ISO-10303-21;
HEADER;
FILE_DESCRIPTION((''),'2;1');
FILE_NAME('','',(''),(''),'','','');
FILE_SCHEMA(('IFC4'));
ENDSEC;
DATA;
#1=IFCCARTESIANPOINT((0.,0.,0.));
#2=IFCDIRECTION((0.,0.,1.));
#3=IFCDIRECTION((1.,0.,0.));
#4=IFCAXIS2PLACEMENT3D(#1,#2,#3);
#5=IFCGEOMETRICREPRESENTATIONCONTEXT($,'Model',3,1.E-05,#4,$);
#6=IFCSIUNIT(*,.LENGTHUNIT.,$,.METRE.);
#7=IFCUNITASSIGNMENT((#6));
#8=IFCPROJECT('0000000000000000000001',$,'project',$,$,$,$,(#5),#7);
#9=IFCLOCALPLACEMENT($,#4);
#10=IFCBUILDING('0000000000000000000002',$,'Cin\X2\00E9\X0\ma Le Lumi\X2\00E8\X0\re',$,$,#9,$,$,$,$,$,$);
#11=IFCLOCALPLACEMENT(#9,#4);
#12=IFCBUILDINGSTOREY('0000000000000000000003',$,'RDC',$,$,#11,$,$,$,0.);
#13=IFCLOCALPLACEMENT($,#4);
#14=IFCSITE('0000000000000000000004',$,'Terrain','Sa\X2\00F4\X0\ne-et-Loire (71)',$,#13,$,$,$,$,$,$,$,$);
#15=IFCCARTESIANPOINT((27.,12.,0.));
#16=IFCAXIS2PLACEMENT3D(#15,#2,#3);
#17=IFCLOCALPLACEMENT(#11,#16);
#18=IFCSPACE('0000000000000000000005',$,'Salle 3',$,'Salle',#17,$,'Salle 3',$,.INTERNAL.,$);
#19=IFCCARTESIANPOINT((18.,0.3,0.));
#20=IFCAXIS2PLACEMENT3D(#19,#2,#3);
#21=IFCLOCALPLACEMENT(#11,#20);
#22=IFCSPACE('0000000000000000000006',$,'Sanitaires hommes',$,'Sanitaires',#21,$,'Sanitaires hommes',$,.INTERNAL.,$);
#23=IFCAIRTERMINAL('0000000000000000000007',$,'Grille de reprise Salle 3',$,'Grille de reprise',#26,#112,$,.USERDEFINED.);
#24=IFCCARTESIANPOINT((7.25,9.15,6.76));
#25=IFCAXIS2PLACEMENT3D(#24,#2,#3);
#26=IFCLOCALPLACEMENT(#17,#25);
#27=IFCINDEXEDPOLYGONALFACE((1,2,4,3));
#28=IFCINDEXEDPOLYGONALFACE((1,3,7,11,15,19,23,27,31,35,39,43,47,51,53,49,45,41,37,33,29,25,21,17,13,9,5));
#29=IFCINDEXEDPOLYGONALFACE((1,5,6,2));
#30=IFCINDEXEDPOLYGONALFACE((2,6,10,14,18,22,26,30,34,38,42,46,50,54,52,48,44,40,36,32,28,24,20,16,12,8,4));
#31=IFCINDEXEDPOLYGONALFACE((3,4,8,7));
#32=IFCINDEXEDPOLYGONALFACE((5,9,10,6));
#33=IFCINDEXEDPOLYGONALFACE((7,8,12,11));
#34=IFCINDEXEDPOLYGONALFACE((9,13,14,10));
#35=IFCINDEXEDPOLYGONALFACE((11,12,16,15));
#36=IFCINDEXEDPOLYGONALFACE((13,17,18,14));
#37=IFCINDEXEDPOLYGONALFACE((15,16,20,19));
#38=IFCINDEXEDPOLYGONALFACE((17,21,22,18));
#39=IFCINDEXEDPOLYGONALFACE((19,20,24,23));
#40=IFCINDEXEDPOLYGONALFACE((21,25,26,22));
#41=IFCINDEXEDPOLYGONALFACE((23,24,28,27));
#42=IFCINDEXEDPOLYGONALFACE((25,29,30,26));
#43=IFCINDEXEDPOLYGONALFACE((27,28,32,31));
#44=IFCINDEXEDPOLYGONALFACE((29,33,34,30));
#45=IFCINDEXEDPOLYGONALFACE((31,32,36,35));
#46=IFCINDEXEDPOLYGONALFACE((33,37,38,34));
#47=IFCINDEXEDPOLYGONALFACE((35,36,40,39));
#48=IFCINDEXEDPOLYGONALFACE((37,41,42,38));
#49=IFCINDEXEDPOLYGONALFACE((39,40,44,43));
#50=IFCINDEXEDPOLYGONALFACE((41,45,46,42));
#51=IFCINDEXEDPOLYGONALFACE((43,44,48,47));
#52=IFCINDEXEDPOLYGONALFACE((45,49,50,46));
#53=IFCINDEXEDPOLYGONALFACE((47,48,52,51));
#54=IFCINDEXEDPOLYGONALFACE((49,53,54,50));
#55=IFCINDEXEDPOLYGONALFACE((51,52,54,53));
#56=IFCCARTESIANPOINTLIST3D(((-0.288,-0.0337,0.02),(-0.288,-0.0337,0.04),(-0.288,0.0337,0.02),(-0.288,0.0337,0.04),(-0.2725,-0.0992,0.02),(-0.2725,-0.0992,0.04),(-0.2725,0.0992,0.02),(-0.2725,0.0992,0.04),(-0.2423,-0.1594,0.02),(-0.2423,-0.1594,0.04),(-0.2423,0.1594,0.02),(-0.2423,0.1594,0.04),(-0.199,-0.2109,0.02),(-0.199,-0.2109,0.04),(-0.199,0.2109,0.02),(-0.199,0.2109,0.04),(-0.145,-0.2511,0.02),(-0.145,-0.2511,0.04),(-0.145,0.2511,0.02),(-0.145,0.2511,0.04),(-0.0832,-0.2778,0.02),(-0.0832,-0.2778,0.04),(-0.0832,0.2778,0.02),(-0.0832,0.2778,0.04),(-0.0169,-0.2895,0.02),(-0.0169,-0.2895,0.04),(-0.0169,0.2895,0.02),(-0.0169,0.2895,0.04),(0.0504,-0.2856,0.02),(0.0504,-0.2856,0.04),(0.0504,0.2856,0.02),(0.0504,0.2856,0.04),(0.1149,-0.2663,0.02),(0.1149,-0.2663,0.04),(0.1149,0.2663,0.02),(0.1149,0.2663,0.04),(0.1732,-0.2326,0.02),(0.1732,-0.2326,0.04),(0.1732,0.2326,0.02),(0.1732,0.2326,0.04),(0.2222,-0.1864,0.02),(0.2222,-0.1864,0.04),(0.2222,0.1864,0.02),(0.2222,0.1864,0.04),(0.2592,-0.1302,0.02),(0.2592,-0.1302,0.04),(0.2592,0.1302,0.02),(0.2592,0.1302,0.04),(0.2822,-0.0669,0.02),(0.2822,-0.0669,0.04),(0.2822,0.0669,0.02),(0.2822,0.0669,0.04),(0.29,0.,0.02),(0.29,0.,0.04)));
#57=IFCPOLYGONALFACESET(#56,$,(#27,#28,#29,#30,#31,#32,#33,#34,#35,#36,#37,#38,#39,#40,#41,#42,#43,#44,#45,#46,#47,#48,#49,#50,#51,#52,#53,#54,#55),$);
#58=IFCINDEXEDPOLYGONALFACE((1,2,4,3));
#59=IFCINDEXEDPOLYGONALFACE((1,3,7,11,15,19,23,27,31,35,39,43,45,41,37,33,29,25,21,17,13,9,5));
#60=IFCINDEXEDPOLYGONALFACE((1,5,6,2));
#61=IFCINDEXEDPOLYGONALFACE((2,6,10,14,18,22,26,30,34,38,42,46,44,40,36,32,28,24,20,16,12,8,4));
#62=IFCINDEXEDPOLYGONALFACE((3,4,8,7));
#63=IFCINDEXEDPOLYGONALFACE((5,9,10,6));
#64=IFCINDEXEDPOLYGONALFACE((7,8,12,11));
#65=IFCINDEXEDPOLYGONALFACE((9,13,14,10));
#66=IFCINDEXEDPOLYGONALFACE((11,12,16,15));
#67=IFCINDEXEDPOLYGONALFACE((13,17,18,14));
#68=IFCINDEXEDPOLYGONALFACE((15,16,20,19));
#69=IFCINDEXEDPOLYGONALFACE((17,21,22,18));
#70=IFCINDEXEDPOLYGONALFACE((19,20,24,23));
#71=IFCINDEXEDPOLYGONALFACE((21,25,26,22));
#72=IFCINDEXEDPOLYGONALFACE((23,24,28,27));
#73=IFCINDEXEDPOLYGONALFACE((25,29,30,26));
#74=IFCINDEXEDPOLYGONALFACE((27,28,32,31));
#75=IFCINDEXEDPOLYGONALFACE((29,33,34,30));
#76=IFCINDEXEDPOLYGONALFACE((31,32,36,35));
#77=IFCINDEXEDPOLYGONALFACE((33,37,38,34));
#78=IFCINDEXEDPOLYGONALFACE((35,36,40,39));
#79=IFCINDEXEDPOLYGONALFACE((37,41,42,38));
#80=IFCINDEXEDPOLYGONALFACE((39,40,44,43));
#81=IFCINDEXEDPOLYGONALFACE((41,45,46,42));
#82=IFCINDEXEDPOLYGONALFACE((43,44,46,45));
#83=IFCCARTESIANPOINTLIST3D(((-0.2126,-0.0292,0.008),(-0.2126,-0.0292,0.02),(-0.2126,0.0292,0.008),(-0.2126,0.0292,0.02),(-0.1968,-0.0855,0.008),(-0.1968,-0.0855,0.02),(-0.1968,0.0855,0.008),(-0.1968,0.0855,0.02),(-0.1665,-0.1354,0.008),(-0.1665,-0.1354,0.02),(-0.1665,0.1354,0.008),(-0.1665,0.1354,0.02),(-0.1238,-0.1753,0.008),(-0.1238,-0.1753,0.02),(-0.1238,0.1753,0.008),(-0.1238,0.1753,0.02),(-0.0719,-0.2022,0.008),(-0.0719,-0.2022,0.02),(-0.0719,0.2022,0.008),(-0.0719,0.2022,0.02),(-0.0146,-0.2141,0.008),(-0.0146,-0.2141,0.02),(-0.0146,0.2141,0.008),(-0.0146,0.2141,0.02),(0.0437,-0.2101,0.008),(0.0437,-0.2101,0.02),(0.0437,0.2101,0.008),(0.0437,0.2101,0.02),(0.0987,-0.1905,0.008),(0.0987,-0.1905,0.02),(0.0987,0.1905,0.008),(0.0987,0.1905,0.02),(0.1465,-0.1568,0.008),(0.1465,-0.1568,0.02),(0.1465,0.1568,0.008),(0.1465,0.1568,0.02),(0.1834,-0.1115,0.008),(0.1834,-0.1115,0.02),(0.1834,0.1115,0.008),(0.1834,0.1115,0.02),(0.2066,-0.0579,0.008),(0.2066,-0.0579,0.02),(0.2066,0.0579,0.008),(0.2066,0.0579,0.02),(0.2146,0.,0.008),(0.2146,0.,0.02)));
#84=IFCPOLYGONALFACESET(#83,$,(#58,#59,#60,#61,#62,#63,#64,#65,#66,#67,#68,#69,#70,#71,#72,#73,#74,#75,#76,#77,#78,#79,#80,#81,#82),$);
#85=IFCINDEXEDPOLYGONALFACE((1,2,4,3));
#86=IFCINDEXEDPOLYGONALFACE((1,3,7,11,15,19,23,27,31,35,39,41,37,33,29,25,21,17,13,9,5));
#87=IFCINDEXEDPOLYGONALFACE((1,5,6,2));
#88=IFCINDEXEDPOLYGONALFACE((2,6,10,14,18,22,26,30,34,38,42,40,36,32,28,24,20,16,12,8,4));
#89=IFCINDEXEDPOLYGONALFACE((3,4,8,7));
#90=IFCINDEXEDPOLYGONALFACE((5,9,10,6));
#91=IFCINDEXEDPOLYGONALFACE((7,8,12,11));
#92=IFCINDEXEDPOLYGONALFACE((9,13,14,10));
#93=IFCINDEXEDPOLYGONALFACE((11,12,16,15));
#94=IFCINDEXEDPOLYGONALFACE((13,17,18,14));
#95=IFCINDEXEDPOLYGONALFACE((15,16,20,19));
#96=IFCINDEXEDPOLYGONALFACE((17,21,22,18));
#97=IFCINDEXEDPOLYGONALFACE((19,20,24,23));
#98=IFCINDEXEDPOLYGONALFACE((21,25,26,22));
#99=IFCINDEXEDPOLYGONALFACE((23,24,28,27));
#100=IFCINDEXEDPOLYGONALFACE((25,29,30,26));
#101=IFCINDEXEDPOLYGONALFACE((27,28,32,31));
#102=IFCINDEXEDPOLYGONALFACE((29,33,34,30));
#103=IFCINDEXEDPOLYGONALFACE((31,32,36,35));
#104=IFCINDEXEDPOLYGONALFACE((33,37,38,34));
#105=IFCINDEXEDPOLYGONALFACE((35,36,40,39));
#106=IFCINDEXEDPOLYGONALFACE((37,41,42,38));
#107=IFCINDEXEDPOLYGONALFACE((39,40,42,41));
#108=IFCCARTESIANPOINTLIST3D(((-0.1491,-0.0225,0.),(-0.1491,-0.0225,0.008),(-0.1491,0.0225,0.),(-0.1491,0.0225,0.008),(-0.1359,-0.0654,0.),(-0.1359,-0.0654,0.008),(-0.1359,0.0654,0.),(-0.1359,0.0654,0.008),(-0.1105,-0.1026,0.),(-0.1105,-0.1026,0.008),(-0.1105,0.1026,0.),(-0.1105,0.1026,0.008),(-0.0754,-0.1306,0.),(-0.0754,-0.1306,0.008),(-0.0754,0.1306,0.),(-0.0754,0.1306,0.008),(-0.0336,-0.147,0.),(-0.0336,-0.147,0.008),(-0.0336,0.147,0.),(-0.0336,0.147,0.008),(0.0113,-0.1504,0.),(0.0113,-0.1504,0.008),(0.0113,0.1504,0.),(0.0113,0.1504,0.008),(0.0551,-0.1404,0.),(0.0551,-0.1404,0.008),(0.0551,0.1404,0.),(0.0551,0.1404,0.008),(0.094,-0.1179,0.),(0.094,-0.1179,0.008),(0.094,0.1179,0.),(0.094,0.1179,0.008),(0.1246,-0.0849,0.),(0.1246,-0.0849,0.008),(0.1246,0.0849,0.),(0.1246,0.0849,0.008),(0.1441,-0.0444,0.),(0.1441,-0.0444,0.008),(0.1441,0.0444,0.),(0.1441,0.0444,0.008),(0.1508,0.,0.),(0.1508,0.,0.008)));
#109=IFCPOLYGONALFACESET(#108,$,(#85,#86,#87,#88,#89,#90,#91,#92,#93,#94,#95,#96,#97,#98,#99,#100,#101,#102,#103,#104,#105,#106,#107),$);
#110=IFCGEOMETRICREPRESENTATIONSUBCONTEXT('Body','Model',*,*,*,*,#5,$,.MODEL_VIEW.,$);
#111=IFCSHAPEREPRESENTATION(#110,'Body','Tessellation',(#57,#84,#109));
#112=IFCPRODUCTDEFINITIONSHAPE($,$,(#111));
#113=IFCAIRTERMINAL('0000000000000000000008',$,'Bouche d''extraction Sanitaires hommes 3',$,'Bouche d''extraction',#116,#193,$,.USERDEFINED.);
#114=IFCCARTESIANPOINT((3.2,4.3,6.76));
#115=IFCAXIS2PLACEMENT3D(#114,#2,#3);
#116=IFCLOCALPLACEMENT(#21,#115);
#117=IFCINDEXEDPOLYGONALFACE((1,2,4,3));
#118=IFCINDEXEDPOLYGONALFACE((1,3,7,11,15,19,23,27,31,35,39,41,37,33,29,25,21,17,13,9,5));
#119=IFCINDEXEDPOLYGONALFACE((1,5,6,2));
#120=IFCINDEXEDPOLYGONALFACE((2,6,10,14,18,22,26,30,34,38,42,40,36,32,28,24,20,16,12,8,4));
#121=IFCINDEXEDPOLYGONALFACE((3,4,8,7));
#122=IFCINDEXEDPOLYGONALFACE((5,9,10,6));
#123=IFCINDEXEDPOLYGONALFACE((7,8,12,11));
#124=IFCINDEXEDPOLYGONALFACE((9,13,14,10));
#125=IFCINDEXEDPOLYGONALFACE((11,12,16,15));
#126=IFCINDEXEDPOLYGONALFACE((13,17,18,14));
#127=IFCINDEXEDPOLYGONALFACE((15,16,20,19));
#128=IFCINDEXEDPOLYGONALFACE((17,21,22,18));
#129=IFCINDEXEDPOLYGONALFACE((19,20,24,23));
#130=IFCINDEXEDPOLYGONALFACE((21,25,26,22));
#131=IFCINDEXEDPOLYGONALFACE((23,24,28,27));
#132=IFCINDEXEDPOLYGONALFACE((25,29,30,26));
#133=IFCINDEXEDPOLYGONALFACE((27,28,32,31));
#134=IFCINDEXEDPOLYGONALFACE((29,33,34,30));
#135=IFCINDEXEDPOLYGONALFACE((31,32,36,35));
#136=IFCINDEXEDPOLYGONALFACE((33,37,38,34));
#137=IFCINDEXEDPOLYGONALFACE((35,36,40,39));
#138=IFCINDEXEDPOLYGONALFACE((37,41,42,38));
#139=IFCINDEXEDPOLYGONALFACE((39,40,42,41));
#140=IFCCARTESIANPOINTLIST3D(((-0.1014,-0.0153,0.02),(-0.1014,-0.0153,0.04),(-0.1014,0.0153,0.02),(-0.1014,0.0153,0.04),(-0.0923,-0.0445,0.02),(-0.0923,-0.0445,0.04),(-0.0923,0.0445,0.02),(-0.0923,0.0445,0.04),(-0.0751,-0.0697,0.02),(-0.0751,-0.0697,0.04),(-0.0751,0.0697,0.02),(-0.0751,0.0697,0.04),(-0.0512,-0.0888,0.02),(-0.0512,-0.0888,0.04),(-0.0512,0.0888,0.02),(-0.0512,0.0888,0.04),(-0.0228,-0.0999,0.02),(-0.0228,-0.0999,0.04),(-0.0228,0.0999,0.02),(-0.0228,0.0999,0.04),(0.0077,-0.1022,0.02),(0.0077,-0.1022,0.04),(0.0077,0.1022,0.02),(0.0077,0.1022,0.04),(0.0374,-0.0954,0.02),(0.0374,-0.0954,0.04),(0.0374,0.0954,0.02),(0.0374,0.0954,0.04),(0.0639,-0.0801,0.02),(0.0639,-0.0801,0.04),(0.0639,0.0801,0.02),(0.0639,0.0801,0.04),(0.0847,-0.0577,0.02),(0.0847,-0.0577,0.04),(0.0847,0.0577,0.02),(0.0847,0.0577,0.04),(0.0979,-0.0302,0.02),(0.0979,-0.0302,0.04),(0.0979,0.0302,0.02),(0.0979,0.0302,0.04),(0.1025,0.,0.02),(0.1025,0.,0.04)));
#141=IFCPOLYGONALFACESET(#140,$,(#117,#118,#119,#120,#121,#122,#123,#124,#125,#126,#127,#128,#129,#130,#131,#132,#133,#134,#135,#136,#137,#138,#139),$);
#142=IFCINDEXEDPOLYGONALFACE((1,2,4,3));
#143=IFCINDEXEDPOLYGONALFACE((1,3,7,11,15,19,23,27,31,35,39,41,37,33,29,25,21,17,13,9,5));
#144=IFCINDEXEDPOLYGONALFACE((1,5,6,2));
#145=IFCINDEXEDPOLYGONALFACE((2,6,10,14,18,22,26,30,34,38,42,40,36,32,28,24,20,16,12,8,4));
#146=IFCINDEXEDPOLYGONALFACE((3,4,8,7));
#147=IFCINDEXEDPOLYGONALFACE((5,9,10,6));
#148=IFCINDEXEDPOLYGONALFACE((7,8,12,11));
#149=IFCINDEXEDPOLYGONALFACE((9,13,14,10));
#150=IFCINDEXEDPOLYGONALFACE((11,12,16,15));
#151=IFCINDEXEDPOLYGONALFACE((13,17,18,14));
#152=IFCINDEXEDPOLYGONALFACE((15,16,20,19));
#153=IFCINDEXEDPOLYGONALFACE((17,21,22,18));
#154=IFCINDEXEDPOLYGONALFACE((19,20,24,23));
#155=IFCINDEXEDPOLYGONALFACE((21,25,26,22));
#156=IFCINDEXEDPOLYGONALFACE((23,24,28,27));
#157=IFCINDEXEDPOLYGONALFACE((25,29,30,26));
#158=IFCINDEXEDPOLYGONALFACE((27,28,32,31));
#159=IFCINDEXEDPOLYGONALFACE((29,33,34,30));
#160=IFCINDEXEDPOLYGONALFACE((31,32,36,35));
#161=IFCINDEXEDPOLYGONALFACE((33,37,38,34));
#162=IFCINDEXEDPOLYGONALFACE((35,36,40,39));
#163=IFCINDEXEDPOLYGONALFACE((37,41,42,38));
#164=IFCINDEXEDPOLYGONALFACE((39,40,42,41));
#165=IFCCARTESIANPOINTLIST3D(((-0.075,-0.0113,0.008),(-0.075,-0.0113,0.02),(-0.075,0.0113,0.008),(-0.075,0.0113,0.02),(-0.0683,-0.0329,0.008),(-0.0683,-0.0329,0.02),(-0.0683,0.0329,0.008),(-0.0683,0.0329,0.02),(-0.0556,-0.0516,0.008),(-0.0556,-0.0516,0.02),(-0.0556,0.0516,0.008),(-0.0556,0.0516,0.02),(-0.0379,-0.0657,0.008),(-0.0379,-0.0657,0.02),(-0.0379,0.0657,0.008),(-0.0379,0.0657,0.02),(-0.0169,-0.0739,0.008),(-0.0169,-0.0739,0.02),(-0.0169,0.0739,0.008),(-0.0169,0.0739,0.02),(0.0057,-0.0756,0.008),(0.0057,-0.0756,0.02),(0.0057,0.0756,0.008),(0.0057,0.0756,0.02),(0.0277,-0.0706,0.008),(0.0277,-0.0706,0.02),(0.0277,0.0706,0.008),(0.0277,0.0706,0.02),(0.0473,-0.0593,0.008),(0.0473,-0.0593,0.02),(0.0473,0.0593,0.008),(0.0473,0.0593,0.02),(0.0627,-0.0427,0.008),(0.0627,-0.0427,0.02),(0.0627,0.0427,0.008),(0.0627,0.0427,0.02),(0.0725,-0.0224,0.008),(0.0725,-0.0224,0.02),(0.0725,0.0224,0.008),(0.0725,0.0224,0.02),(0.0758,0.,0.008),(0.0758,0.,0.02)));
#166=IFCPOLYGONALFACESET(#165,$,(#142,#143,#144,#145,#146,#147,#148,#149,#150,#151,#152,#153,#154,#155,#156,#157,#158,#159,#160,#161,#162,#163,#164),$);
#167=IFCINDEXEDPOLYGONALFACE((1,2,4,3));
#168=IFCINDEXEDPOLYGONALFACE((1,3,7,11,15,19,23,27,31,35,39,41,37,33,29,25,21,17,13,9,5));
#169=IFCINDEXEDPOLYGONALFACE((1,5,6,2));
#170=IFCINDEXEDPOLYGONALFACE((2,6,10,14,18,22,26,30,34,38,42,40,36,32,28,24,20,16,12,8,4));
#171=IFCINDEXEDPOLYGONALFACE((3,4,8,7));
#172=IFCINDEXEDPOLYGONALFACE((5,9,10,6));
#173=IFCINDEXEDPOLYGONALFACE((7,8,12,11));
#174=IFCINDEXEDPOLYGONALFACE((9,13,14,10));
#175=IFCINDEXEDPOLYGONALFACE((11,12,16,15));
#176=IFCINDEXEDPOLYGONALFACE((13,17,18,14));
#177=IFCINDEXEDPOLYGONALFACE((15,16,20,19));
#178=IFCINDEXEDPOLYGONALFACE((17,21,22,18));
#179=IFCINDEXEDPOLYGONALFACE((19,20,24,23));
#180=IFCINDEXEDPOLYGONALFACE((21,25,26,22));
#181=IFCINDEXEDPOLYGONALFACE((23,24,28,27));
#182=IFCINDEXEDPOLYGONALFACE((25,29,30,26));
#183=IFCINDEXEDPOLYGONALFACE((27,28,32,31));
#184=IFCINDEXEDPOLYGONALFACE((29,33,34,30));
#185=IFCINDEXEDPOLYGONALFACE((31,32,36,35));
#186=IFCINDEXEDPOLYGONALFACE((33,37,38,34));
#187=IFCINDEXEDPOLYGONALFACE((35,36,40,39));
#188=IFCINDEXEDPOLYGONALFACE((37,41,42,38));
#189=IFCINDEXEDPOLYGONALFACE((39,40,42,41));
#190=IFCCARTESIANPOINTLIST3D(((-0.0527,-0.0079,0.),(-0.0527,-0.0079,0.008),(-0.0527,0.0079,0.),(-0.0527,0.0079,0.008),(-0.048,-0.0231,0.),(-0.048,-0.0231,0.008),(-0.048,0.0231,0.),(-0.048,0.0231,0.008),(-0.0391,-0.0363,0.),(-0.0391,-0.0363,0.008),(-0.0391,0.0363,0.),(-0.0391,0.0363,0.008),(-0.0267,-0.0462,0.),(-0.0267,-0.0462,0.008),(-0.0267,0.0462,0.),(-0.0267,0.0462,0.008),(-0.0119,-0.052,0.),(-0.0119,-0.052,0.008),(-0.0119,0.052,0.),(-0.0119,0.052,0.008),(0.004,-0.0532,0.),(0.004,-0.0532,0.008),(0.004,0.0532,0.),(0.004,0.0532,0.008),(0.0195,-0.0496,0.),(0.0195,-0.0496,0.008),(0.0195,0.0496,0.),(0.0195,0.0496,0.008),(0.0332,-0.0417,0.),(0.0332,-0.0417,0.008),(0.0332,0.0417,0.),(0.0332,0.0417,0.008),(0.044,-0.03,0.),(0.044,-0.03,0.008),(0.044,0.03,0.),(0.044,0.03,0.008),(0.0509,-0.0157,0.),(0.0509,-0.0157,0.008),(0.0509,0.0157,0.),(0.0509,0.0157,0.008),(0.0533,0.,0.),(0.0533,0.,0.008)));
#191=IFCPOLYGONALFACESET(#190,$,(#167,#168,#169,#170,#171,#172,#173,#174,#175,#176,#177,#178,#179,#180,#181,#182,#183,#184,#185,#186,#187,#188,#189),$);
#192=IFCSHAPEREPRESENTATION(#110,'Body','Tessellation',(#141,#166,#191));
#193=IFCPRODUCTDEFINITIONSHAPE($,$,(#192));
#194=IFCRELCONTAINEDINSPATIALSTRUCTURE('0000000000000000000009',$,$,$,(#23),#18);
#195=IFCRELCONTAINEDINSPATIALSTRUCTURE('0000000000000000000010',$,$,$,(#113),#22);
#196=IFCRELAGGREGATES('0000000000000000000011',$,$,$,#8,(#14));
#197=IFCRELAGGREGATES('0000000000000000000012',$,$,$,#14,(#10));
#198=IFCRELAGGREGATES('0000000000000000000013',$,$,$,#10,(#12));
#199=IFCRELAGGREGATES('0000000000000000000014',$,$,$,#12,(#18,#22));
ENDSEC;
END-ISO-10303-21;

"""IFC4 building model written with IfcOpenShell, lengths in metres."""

from ifc_helpers import new_model, si_unit, frame, origin_with_axes, place, context, subcontext, project, spatial, circle, extrude, element, save


model = new_model("IFC4")

# Units and contexts
model_context = context("Model", 3, precision=1e-05, world=origin_with_axes())
body_context = subcontext(model_context, "Body", "Model", "MODEL_VIEW")
ifc_project = project(units=[si_unit("LENGTHUNIT", "METRE")], contexts=[model_context])

# Site, building, storey
site_placement = place(None, origin_with_axes())
site = spatial("IfcSite", under=ifc_project, at=site_placement, Name="Terrain", Description="Saône-et-Loire (71)")
building_placement = place(None, origin_with_axes())
building = spatial("IfcBuilding", under=site, at=building_placement, Name="Cinéma Le Lumière")
storey_placement = place(building_placement, origin_with_axes())
storey = spatial("IfcBuildingStorey", under=building, at=storey_placement, Name="RDC", Elevation=0.0)

# Shared definitions
space_1_placement = place(storey_placement, frame((27.0, 12.0, 0.0), z_axis=(0.0, 0.0, 1.0), x_axis=(1.0, 0.0, 0.0)))
space_1 = spatial("IfcSpace", under=storey, at=space_1_placement, Name="Salle 3", ObjectType="Salle", LongName="Salle 3", PredefinedType="INTERNAL")

# Air terminal
air_terminal_1_placement = place(space_1_placement, frame((7.25, 9.15, 6.76), z_axis=(0.0, 0.0, 1.0), x_axis=(1.0, 0.0, 0.0)))
element("IfcAirTerminal", 1, at=air_terminal_1_placement, inside=space_1, Name="Grille de reprise Salle 3", ObjectType="Grille de reprise", PredefinedType="USERDEFINED", context=body_context, shape_type="SweptSolid", body=[
    extrude(circle(Radius=0.29), frame((0.0, 0.0, 0.02), z_axis=(0.0, 0.0, 1.0), x_axis=(1.0, 0.0, 0.0)), (0.0, 0.0, 1.0), 0.02),
    extrude(circle(Radius=0.2146), frame((0.0, 0.0, 0.008), z_axis=(0.0, 0.0, 1.0), x_axis=(1.0, 0.0, 0.0)), (0.0, 0.0, 1.0), 0.012),
    extrude(circle(Radius=0.1508), origin_with_axes(), (0.0, 0.0, 1.0), 0.008),
])

# Shared definitions
space_2_placement = place(storey_placement, frame((18.0, 0.3, 0.0), z_axis=(0.0, 0.0, 1.0), x_axis=(1.0, 0.0, 0.0)))
space_2 = spatial("IfcSpace", under=storey, at=space_2_placement, Name="Sanitaires hommes", ObjectType="Sanitaires", LongName="Sanitaires hommes", PredefinedType="INTERNAL")

# Air terminal
air_terminal_2_placement = place(space_2_placement, frame((3.2, 4.3, 6.76), z_axis=(0.0, 0.0, 1.0), x_axis=(1.0, 0.0, 0.0)))
element("IfcAirTerminal", 2, at=air_terminal_2_placement, inside=space_2, Name="Bouche d'extraction Sanitaires hommes 3", ObjectType="Bouche d'extraction", PredefinedType="USERDEFINED", context=body_context, shape_type="SweptSolid", body=[
    extrude(circle(Radius=0.1025), frame((0.0, 0.0, 0.02), z_axis=(0.0, 0.0, 1.0), x_axis=(1.0, 0.0, 0.0)), (0.0, 0.0, 1.0), 0.02),
    extrude(circle(Radius=0.0759), frame((0.0, 0.0, 0.008), z_axis=(0.0, 0.0, 1.0), x_axis=(1.0, 0.0, 0.0)), (0.0, 0.0, 1.0), 0.012),
    extrude(circle(Radius=0.0533), origin_with_axes(), (0.0, 0.0, 1.0), 0.008),
])

save(model, "model.ifc")
